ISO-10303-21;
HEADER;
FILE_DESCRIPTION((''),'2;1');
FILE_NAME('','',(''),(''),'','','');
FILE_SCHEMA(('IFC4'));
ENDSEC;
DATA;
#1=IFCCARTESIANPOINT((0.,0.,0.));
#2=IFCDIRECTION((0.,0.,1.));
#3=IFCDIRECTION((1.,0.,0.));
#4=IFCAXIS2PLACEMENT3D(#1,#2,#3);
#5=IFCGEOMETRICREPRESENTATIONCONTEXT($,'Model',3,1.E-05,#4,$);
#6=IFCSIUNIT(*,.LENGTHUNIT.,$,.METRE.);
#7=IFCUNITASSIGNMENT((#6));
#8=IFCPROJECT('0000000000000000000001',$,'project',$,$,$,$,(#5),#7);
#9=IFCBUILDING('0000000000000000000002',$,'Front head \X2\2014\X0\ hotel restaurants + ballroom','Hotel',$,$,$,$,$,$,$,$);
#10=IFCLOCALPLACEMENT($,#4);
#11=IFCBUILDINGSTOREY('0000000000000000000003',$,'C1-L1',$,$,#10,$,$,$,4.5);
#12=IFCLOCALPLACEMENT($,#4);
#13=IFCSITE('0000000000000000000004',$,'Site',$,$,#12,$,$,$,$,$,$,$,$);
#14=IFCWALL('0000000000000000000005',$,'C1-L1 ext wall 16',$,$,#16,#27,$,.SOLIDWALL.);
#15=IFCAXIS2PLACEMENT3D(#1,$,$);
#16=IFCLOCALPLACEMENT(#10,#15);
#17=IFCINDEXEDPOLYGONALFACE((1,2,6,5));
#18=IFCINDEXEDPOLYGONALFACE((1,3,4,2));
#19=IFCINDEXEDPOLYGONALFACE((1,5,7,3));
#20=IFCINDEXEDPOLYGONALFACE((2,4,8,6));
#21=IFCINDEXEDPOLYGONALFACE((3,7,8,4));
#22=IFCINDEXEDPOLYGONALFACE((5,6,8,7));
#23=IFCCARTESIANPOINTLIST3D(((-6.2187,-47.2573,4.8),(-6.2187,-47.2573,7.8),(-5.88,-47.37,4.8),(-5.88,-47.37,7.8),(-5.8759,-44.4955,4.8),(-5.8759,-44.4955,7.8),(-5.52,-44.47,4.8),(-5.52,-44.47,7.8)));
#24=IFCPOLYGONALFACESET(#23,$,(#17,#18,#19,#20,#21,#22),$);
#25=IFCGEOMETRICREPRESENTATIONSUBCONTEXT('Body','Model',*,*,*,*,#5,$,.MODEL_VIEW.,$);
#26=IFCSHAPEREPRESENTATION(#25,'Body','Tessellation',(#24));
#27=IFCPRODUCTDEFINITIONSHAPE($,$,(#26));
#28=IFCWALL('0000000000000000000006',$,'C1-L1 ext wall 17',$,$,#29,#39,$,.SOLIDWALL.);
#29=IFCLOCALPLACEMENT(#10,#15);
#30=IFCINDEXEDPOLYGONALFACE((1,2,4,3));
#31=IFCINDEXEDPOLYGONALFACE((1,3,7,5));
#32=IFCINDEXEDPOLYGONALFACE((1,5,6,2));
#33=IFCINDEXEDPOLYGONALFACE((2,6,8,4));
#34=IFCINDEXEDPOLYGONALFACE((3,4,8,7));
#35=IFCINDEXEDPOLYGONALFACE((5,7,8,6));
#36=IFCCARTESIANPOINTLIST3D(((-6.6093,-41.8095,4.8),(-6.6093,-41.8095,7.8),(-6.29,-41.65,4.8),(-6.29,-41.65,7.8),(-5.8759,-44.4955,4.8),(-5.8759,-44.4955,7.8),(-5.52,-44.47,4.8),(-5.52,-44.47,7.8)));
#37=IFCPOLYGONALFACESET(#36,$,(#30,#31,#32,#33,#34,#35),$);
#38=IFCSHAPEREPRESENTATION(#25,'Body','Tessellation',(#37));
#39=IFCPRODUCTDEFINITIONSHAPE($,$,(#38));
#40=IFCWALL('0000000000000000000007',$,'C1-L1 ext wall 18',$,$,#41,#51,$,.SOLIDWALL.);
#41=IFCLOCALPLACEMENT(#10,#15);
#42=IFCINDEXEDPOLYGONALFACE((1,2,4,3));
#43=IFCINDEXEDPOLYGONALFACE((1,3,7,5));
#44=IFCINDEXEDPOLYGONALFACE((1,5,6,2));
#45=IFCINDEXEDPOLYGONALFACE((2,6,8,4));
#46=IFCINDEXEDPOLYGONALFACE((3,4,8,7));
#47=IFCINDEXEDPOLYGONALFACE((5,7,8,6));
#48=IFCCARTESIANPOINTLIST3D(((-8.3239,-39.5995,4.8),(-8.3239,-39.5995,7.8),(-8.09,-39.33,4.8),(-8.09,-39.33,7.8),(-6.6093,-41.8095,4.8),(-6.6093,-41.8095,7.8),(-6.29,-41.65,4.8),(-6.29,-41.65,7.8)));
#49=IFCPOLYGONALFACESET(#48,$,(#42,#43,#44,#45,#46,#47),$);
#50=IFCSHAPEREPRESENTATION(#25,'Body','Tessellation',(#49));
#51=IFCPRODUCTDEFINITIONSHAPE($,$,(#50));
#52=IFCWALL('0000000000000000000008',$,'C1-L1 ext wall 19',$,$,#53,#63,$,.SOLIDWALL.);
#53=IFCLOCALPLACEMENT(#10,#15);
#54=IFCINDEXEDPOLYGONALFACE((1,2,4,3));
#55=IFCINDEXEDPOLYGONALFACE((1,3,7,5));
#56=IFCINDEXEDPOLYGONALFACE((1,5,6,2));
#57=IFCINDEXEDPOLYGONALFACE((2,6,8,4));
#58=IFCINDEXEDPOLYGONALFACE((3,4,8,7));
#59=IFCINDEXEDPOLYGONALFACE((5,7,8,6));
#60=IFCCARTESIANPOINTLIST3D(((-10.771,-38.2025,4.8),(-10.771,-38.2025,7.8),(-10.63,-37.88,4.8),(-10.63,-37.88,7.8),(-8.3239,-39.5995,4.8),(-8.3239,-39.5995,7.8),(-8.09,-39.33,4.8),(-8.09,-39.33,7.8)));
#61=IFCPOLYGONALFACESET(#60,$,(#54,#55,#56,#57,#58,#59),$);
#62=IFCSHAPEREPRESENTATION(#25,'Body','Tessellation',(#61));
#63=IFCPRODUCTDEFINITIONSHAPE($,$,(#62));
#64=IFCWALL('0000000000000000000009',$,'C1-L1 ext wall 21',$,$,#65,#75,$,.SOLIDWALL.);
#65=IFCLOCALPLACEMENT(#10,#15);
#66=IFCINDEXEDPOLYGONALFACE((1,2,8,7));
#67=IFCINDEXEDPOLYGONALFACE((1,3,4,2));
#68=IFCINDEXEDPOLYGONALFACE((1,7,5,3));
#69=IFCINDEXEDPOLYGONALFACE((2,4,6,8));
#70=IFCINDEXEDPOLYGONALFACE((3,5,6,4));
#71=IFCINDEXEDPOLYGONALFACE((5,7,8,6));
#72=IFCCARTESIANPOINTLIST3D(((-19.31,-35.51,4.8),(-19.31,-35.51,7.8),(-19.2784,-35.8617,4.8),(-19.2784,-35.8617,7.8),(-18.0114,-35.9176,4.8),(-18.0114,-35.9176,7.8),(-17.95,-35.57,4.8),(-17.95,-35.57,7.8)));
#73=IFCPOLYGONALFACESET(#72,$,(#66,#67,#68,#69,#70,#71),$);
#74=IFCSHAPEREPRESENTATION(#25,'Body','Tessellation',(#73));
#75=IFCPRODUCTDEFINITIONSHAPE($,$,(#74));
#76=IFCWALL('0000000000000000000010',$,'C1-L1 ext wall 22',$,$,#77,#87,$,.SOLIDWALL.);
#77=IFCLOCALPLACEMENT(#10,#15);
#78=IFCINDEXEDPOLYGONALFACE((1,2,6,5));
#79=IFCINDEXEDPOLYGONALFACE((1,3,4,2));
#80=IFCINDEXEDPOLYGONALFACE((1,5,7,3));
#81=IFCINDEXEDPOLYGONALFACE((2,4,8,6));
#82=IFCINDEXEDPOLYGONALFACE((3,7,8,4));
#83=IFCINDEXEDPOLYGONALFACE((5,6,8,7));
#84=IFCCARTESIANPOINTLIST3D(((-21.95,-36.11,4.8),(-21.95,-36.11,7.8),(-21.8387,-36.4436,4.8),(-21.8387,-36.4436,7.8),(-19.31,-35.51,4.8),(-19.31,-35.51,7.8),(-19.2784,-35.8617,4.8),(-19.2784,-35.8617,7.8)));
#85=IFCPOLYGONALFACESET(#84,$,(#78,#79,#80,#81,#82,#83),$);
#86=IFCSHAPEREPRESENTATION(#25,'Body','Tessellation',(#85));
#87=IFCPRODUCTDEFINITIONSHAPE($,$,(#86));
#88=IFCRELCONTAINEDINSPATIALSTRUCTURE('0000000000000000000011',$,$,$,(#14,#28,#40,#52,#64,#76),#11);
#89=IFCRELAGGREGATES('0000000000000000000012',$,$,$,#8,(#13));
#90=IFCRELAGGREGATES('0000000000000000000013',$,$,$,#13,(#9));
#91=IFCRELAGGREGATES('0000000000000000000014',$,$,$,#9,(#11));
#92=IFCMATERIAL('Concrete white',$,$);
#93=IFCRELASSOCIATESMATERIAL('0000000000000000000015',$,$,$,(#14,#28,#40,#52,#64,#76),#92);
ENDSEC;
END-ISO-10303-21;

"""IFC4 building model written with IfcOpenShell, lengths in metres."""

from ifc_helpers import new_model, si_unit, frame, origin_with_axes, place, context, subcontext, project, spatial, polyline, outline, extrude, material, element, save


model = new_model("IFC4")

# Units and contexts
model_context = context("Model", 3, precision=1e-05, world=origin_with_axes())
body_context = subcontext(model_context, "Body", "Model", "MODEL_VIEW")
ifc_project = project(units=[si_unit("LENGTHUNIT", "METRE")], contexts=[model_context])

# Site, building, storey
site_placement = place(None, origin_with_axes())
site = spatial("IfcSite", under=ifc_project, at=site_placement, Name="Site")
building = spatial("IfcBuilding", under=site, Name="Front head — hotel restaurants + ballroom", Description="Hotel")
storey_placement = place(None, origin_with_axes())
storey = spatial("IfcBuildingStorey", under=building, at=storey_placement, Name="C1-L1", Elevation=4.5)

# Shared definitions
ifc_material_1 = material(Name="Concrete white")

# Walls
wall_1_placement = place(storey_placement, origin_with_axes())
element("IfcWall", 1, at=wall_1_placement, inside=storey, material=ifc_material_1, Name="C1-L1 ext wall 16", PredefinedType="SOLIDWALL", context=body_context, shape_type="SweptSolid", body=[
    extrude(outline(polyline([(-5.88, -47.37), (-5.52, -44.47), (-5.8759, -44.4955), (-6.2187, -47.2573), (-5.88, -47.37)])), frame((0.0, 0.0, 4.8), z_axis=(0.0, 0.0, 1.0), x_axis=(1.0, 0.0, 0.0)), (0.0, 0.0, 1.0), 3.0),
])
wall_2_placement = place(storey_placement, origin_with_axes())
element("IfcWall", 2, at=wall_2_placement, inside=storey, material=ifc_material_1, Name="C1-L1 ext wall 17", PredefinedType="SOLIDWALL", context=body_context, shape_type="SweptSolid", body=[
    extrude(outline(polyline([(-5.52, -44.47), (-6.29, -41.65), (-6.6093, -41.8095), (-5.8759, -44.4955), (-5.52, -44.47)])), frame((0.0, 0.0, 4.8), z_axis=(0.0, 0.0, 1.0), x_axis=(1.0, 0.0, 0.0)), (0.0, 0.0, 1.0), 3.0),
])
wall_3_placement = place(storey_placement, origin_with_axes())
element("IfcWall", 3, at=wall_3_placement, inside=storey, material=ifc_material_1, Name="C1-L1 ext wall 18", PredefinedType="SOLIDWALL", context=body_context, shape_type="SweptSolid", body=[
    extrude(outline(polyline([(-6.29, -41.65), (-8.09, -39.33), (-8.3239, -39.5995), (-6.6093, -41.8095), (-6.29, -41.65)])), frame((0.0, 0.0, 4.8), z_axis=(0.0, 0.0, 1.0), x_axis=(1.0, 0.0, 0.0)), (0.0, 0.0, 1.0), 3.0),
])
wall_4_placement = place(storey_placement, origin_with_axes())
element("IfcWall", 4, at=wall_4_placement, inside=storey, material=ifc_material_1, Name="C1-L1 ext wall 19", PredefinedType="SOLIDWALL", context=body_context, shape_type="SweptSolid", body=[
    extrude(outline(polyline([(-8.09, -39.33), (-10.63, -37.88), (-10.771, -38.2025), (-8.3239, -39.5995), (-8.09, -39.33)])), frame((0.0, 0.0, 4.8), z_axis=(0.0, 0.0, 1.0), x_axis=(1.0, 0.0, 0.0)), (0.0, 0.0, 1.0), 3.0),
])

# Walls
wall_5_placement = place(storey_placement, origin_with_axes())
element("IfcWall", 5, at=wall_5_placement, inside=storey, material=ifc_material_1, Name="C1-L1 ext wall 21", PredefinedType="SOLIDWALL", context=body_context, shape_type="SweptSolid", body=[
    extrude(outline(polyline([(-17.95, -35.57), (-19.31, -35.51), (-19.2784, -35.8617), (-18.0114, -35.9176), (-17.95, -35.57)])), frame((0.0, 0.0, 4.8), z_axis=(0.0, 0.0, 1.0), x_axis=(1.0, 0.0, 0.0)), (0.0, 0.0, 1.0), 3.0),
])
wall_6_placement = place(storey_placement, origin_with_axes())
element("IfcWall", 6, at=wall_6_placement, inside=storey, material=ifc_material_1, Name="C1-L1 ext wall 22", PredefinedType="SOLIDWALL", context=body_context, shape_type="SweptSolid", body=[
    extrude(outline(polyline([(-19.31, -35.51), (-21.95, -36.11), (-21.8387, -36.4436), (-19.2784, -35.8617), (-19.31, -35.51)])), frame((0.0, 0.0, 4.8), z_axis=(0.0, 0.0, 1.0), x_axis=(1.0, 0.0, 0.0)), (0.0, 0.0, 1.0), 3.0),
])

save(model, "model.ifc")
